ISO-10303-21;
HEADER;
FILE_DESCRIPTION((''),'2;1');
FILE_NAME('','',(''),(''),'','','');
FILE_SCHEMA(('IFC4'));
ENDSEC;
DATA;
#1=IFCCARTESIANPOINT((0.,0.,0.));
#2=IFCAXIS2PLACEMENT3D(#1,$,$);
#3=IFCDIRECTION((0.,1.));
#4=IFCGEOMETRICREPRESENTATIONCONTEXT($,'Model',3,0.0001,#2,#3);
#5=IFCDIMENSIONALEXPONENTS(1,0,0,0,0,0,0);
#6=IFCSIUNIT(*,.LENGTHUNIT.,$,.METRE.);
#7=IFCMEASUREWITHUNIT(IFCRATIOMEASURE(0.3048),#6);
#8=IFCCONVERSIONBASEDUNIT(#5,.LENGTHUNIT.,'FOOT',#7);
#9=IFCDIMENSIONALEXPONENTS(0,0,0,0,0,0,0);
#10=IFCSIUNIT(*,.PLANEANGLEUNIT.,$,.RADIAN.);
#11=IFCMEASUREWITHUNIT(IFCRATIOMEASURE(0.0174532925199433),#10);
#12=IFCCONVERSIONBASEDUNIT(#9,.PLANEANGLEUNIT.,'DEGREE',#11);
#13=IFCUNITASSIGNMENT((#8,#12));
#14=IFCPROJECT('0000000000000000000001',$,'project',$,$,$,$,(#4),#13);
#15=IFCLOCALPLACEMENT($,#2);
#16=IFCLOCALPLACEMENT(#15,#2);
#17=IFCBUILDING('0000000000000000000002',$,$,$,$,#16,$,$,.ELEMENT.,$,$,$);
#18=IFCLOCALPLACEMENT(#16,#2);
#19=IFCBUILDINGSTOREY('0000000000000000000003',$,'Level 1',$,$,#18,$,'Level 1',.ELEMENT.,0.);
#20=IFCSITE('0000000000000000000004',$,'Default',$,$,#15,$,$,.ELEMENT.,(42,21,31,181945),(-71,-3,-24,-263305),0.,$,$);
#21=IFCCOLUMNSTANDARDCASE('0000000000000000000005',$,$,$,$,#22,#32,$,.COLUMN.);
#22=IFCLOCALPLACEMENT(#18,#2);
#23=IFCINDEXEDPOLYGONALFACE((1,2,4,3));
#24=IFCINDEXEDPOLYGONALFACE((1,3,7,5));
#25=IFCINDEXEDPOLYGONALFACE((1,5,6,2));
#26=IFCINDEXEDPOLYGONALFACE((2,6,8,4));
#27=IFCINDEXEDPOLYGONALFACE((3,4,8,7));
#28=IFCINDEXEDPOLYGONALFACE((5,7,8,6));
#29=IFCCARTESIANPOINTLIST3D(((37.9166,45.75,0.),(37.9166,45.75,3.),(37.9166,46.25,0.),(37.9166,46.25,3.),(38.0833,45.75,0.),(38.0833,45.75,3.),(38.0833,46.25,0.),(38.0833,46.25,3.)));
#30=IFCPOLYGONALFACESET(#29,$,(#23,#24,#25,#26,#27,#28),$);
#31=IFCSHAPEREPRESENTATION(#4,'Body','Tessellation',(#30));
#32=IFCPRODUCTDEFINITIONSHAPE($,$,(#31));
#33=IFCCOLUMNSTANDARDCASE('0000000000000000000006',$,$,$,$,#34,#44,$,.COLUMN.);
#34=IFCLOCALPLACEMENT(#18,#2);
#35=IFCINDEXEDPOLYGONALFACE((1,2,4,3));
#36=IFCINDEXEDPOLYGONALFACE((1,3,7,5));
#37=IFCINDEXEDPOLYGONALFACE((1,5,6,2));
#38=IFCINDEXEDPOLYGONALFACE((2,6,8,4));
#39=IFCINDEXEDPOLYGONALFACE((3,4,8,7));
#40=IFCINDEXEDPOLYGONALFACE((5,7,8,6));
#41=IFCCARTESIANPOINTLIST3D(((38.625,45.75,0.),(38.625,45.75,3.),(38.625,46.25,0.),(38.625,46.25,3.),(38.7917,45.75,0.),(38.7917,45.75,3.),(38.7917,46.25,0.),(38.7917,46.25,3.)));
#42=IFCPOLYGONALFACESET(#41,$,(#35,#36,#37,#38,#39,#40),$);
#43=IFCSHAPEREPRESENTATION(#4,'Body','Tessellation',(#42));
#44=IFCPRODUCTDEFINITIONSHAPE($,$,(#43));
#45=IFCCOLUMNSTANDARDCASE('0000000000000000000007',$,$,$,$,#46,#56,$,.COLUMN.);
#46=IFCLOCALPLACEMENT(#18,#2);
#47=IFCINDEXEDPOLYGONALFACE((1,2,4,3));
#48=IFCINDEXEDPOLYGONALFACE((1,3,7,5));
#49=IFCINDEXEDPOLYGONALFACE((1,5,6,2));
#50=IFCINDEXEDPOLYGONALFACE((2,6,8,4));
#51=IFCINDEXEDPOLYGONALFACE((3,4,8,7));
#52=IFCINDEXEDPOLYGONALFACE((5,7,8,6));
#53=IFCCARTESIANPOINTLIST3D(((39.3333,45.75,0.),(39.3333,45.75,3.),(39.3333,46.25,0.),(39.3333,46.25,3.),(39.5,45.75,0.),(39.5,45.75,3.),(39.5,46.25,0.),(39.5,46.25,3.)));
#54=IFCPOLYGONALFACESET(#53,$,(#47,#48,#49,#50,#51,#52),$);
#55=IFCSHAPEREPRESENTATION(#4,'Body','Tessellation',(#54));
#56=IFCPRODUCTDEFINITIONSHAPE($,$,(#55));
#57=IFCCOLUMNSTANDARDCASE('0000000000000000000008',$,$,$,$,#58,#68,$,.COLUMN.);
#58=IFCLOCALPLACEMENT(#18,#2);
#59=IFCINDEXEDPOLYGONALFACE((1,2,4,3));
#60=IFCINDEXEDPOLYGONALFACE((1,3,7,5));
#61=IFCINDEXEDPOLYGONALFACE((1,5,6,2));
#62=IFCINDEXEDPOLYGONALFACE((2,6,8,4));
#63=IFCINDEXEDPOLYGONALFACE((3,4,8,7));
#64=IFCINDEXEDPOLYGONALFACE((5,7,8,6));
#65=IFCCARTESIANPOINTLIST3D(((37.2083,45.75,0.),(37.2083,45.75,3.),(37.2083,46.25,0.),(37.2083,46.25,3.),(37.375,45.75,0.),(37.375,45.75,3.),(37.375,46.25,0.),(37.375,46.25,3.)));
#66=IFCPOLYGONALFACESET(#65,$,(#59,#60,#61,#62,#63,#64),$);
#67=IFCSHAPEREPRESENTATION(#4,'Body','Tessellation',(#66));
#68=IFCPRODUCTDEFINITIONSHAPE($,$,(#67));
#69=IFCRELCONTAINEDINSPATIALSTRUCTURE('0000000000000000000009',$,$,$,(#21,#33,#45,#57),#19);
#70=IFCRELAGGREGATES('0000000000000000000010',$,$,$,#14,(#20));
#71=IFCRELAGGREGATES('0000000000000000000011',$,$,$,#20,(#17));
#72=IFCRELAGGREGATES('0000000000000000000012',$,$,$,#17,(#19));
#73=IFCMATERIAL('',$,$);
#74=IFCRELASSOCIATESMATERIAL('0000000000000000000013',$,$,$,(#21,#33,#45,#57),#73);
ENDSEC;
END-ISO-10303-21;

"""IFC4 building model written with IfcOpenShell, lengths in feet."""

from ifc_helpers import new_model, entity, si_unit, converted_unit, direction, frame, origin, place, context, project, spatial, rectangle, extrude, material, element, save


model = new_model("IFC4")

# Units and contexts
model_context = context("Model", 3, precision=0.0001, world=origin(), true_north=direction((0.0, 1.0)))
ifc_project = project(units=[converted_unit("LENGTHUNIT", "FOOT", entity("IfcRatioMeasure", 0.3048), si_unit("LENGTHUNIT", "METRE"), dimensions=[1, 0, 0, 0, 0, 0, 0]), converted_unit("PLANEANGLEUNIT", "DEGREE", entity("IfcRatioMeasure", 0.0174532925199433), si_unit("PLANEANGLEUNIT", "RADIAN"), dimensions=[0, 0, 0, 0, 0, 0, 0])], contexts=[model_context])

# Site, building, storey
site_placement = place(None, origin())
site = spatial("IfcSite", under=ifc_project, at=site_placement, Name="Default", CompositionType="ELEMENT", RefLatitude=(42, 21, 31, 181945), RefLongitude=(-71, -3, -24, -263305), RefElevation=0.0)
building_placement = place(site_placement, origin())
building = spatial("IfcBuilding", under=site, at=building_placement, CompositionType="ELEMENT")
storey_placement = place(building_placement, origin())
storey = spatial("IfcBuildingStorey", under=building, at=storey_placement, Name="Level 1", LongName="Level 1", CompositionType="ELEMENT", Elevation=0.0)

# Columns
placement = place(storey_placement, frame((-0.25, 46.0, 0.0)))
ifc_material_1 = material(Name="")
for number, where, z_axis, x_axis in (
    (1, (38.25, 0.0, 0.0), (0.0, 0.0, 1.0), (1.0, 0.0, 0.0)),
    (2, (38.9583, 0.0, 0.0), (0.0, 0.0, 1.0), (1.0, 0.0, 0.0)),
    (3, (39.6667, 0.0, 0.0), (0.0, 0.0, 1.0), (1.0, 0.0, 0.0)),
    (4, (37.5417, 0.0, 0.0), (0.0, 0.0, 1.0), (1.0, 0.0, 0.0)),
):
    element("IfcColumnStandardCase", number, at=place(placement, frame(where, z_axis=z_axis, x_axis=x_axis)), inside=storey, material=ifc_material_1, PredefinedType="COLUMN", context=model_context, shape_type="SweptSolid", body=[
        extrude(rectangle(XDim=0.1667, YDim=0.5), origin(), (0.0, 0.0, 1.0), 3.0),
    ])

save(model, "model.ifc")
